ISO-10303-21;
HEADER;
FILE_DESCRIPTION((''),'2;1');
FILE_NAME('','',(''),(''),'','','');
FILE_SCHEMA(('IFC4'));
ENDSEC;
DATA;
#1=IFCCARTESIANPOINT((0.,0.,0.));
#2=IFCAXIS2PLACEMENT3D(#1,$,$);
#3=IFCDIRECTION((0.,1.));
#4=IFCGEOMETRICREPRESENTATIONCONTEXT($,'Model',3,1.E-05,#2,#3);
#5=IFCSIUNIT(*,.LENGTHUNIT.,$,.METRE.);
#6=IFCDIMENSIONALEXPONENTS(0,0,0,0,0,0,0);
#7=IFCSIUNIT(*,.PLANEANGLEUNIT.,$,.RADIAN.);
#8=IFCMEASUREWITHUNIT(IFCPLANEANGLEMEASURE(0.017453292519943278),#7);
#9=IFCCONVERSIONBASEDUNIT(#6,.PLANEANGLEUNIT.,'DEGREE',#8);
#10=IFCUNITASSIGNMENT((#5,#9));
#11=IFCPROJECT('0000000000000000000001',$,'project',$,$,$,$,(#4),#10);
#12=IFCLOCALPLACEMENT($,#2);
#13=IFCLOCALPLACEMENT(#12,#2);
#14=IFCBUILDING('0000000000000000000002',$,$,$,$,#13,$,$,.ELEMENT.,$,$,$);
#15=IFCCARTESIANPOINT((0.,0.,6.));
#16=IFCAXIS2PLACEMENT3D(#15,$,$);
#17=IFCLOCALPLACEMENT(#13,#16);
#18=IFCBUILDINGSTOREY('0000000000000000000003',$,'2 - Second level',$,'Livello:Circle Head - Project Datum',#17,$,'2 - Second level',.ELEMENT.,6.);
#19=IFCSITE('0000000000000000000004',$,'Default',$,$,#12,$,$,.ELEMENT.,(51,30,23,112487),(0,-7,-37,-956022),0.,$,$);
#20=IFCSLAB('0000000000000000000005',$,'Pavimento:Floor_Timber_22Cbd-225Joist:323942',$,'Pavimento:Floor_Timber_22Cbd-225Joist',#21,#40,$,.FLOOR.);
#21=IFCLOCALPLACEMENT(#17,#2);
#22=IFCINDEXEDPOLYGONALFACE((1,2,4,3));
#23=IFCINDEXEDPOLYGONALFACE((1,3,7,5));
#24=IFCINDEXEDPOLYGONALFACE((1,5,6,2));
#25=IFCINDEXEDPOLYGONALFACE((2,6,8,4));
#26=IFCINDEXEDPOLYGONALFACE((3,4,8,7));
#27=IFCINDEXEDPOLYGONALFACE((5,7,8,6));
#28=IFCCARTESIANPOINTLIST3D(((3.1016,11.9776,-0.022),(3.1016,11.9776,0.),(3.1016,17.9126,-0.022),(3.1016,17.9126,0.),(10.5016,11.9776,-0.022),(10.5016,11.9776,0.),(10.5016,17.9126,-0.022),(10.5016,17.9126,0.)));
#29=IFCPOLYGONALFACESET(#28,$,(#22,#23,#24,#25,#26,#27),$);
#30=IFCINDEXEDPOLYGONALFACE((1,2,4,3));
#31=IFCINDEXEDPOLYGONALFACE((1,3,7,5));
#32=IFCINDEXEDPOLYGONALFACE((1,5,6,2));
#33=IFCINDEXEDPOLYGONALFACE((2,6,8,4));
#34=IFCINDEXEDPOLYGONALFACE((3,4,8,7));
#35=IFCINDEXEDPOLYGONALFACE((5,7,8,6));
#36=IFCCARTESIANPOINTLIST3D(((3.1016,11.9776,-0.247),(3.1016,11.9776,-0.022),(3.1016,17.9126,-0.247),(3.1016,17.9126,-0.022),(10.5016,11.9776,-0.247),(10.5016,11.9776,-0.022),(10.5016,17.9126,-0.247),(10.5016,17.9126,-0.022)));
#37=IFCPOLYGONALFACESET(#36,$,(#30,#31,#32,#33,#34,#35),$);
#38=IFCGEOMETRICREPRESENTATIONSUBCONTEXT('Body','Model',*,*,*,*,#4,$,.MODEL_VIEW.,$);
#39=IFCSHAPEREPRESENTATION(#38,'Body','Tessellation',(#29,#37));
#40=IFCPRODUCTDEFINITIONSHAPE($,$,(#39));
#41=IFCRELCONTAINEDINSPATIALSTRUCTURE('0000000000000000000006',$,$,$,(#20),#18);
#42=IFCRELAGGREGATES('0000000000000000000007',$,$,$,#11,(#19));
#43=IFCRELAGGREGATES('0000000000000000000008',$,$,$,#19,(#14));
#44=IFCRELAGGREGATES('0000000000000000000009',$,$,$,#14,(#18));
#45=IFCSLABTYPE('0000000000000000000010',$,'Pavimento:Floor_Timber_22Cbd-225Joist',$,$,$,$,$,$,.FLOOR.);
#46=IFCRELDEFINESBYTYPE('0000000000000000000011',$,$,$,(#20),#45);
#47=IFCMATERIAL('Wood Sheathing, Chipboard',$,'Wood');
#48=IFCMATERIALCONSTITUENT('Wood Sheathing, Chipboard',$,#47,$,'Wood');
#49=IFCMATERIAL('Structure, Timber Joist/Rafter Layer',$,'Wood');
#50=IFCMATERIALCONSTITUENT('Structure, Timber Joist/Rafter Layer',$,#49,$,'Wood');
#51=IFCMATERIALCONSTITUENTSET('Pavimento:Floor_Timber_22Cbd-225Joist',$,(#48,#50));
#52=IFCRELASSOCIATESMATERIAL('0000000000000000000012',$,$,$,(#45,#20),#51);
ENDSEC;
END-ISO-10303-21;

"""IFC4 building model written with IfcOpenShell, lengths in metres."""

from ifc_helpers import new_model, entity, si_unit, converted_unit, direction, frame, origin, place, context, subcontext, project, spatial, indexed_curve, outline, extrude, material, constituent, constituent_set, type_object, element, save


model = new_model("IFC4")

# Units and contexts
model_context = context("Model", 3, precision=1e-05, world=origin(), true_north=direction((0.0, 1.0)))
body_context = subcontext(model_context, "Body", "Model", "MODEL_VIEW")
ifc_project = project(units=[si_unit("LENGTHUNIT", "METRE"), converted_unit("PLANEANGLEUNIT", "DEGREE", entity("IfcPlaneAngleMeasure", 0.017453292519943278), si_unit("PLANEANGLEUNIT", "RADIAN"), dimensions=[0, 0, 0, 0, 0, 0, 0])], contexts=[model_context])

# Site, building, storey
site_placement = place(None, origin())
site = spatial("IfcSite", under=ifc_project, at=site_placement, Name="Default", CompositionType="ELEMENT", RefLatitude=(51, 30, 23, 112487), RefLongitude=(0, -7, -37, -956022), RefElevation=0.0)
building_placement = place(site_placement, origin())
building = spatial("IfcBuilding", under=site, at=building_placement, CompositionType="ELEMENT")
storey_placement = place(building_placement, frame((0.0, 0.0, 6.0)))
storey = spatial("IfcBuildingStorey", under=building, at=storey_placement, Name="2 - Second level", ObjectType="Livello:Circle Head - Project Datum", LongName="2 - Second level", CompositionType="ELEMENT", Elevation=6.0)

# Slab
ifc_material_1 = material(Name="Wood Sheathing, Chipboard", Category="Wood")
ifc_constituent_1 = constituent(ifc_material_1, Name="Wood Sheathing, Chipboard", Category="Wood")
ifc_material_2 = material(Name="Structure, Timber Joist/Rafter Layer", Category="Wood")
ifc_constituent_2 = constituent(ifc_material_2, Name="Structure, Timber Joist/Rafter Layer", Category="Wood")
ifc_constituent_set = constituent_set(constituents=[ifc_constituent_1, ifc_constituent_2], Name="Pavimento:Floor_Timber_22Cbd-225Joist")
slab_type = type_object("IfcSlabType", Name="Pavimento:Floor_Timber_22Cbd-225Joist", PredefinedType="FLOOR", material=ifc_constituent_set)
slab_placement = place(storey_placement, origin())
element("IfcSlab", 1, at=slab_placement, inside=storey, type_object=slab_type, material=ifc_constituent_set, Name="Pavimento:Floor_Timber_22Cbd-225Joist:323942", ObjectType="Pavimento:Floor_Timber_22Cbd-225Joist", PredefinedType="FLOOR", context=body_context, shape_type="SweptSolid", body=[
    extrude(outline(indexed_curve([(-2.9675, -3.7), (2.9675, -3.7), (2.9675, 3.7), (-2.9675, 3.7), (-2.9675, -3.7)], self_intersect=False)), frame((6.8016, 14.9451, -0.022), z_axis=(0.0, 0.0, 1.0), x_axis=(0.0, -1.0, 0.0)), (0.0, 0.0, 1.0), 0.022),
    extrude(outline(indexed_curve([(-2.9675, -3.7), (2.9675, -3.7), (2.9675, 3.7), (-2.9675, 3.7), (-2.9675, -3.7)], self_intersect=False)), frame((6.8016, 14.9451, -0.247), z_axis=(0.0, 0.0, 1.0), x_axis=(0.0, -1.0, 0.0)), (0.0, 0.0, 1.0), 0.225),
])

save(model, "model.ifc")
